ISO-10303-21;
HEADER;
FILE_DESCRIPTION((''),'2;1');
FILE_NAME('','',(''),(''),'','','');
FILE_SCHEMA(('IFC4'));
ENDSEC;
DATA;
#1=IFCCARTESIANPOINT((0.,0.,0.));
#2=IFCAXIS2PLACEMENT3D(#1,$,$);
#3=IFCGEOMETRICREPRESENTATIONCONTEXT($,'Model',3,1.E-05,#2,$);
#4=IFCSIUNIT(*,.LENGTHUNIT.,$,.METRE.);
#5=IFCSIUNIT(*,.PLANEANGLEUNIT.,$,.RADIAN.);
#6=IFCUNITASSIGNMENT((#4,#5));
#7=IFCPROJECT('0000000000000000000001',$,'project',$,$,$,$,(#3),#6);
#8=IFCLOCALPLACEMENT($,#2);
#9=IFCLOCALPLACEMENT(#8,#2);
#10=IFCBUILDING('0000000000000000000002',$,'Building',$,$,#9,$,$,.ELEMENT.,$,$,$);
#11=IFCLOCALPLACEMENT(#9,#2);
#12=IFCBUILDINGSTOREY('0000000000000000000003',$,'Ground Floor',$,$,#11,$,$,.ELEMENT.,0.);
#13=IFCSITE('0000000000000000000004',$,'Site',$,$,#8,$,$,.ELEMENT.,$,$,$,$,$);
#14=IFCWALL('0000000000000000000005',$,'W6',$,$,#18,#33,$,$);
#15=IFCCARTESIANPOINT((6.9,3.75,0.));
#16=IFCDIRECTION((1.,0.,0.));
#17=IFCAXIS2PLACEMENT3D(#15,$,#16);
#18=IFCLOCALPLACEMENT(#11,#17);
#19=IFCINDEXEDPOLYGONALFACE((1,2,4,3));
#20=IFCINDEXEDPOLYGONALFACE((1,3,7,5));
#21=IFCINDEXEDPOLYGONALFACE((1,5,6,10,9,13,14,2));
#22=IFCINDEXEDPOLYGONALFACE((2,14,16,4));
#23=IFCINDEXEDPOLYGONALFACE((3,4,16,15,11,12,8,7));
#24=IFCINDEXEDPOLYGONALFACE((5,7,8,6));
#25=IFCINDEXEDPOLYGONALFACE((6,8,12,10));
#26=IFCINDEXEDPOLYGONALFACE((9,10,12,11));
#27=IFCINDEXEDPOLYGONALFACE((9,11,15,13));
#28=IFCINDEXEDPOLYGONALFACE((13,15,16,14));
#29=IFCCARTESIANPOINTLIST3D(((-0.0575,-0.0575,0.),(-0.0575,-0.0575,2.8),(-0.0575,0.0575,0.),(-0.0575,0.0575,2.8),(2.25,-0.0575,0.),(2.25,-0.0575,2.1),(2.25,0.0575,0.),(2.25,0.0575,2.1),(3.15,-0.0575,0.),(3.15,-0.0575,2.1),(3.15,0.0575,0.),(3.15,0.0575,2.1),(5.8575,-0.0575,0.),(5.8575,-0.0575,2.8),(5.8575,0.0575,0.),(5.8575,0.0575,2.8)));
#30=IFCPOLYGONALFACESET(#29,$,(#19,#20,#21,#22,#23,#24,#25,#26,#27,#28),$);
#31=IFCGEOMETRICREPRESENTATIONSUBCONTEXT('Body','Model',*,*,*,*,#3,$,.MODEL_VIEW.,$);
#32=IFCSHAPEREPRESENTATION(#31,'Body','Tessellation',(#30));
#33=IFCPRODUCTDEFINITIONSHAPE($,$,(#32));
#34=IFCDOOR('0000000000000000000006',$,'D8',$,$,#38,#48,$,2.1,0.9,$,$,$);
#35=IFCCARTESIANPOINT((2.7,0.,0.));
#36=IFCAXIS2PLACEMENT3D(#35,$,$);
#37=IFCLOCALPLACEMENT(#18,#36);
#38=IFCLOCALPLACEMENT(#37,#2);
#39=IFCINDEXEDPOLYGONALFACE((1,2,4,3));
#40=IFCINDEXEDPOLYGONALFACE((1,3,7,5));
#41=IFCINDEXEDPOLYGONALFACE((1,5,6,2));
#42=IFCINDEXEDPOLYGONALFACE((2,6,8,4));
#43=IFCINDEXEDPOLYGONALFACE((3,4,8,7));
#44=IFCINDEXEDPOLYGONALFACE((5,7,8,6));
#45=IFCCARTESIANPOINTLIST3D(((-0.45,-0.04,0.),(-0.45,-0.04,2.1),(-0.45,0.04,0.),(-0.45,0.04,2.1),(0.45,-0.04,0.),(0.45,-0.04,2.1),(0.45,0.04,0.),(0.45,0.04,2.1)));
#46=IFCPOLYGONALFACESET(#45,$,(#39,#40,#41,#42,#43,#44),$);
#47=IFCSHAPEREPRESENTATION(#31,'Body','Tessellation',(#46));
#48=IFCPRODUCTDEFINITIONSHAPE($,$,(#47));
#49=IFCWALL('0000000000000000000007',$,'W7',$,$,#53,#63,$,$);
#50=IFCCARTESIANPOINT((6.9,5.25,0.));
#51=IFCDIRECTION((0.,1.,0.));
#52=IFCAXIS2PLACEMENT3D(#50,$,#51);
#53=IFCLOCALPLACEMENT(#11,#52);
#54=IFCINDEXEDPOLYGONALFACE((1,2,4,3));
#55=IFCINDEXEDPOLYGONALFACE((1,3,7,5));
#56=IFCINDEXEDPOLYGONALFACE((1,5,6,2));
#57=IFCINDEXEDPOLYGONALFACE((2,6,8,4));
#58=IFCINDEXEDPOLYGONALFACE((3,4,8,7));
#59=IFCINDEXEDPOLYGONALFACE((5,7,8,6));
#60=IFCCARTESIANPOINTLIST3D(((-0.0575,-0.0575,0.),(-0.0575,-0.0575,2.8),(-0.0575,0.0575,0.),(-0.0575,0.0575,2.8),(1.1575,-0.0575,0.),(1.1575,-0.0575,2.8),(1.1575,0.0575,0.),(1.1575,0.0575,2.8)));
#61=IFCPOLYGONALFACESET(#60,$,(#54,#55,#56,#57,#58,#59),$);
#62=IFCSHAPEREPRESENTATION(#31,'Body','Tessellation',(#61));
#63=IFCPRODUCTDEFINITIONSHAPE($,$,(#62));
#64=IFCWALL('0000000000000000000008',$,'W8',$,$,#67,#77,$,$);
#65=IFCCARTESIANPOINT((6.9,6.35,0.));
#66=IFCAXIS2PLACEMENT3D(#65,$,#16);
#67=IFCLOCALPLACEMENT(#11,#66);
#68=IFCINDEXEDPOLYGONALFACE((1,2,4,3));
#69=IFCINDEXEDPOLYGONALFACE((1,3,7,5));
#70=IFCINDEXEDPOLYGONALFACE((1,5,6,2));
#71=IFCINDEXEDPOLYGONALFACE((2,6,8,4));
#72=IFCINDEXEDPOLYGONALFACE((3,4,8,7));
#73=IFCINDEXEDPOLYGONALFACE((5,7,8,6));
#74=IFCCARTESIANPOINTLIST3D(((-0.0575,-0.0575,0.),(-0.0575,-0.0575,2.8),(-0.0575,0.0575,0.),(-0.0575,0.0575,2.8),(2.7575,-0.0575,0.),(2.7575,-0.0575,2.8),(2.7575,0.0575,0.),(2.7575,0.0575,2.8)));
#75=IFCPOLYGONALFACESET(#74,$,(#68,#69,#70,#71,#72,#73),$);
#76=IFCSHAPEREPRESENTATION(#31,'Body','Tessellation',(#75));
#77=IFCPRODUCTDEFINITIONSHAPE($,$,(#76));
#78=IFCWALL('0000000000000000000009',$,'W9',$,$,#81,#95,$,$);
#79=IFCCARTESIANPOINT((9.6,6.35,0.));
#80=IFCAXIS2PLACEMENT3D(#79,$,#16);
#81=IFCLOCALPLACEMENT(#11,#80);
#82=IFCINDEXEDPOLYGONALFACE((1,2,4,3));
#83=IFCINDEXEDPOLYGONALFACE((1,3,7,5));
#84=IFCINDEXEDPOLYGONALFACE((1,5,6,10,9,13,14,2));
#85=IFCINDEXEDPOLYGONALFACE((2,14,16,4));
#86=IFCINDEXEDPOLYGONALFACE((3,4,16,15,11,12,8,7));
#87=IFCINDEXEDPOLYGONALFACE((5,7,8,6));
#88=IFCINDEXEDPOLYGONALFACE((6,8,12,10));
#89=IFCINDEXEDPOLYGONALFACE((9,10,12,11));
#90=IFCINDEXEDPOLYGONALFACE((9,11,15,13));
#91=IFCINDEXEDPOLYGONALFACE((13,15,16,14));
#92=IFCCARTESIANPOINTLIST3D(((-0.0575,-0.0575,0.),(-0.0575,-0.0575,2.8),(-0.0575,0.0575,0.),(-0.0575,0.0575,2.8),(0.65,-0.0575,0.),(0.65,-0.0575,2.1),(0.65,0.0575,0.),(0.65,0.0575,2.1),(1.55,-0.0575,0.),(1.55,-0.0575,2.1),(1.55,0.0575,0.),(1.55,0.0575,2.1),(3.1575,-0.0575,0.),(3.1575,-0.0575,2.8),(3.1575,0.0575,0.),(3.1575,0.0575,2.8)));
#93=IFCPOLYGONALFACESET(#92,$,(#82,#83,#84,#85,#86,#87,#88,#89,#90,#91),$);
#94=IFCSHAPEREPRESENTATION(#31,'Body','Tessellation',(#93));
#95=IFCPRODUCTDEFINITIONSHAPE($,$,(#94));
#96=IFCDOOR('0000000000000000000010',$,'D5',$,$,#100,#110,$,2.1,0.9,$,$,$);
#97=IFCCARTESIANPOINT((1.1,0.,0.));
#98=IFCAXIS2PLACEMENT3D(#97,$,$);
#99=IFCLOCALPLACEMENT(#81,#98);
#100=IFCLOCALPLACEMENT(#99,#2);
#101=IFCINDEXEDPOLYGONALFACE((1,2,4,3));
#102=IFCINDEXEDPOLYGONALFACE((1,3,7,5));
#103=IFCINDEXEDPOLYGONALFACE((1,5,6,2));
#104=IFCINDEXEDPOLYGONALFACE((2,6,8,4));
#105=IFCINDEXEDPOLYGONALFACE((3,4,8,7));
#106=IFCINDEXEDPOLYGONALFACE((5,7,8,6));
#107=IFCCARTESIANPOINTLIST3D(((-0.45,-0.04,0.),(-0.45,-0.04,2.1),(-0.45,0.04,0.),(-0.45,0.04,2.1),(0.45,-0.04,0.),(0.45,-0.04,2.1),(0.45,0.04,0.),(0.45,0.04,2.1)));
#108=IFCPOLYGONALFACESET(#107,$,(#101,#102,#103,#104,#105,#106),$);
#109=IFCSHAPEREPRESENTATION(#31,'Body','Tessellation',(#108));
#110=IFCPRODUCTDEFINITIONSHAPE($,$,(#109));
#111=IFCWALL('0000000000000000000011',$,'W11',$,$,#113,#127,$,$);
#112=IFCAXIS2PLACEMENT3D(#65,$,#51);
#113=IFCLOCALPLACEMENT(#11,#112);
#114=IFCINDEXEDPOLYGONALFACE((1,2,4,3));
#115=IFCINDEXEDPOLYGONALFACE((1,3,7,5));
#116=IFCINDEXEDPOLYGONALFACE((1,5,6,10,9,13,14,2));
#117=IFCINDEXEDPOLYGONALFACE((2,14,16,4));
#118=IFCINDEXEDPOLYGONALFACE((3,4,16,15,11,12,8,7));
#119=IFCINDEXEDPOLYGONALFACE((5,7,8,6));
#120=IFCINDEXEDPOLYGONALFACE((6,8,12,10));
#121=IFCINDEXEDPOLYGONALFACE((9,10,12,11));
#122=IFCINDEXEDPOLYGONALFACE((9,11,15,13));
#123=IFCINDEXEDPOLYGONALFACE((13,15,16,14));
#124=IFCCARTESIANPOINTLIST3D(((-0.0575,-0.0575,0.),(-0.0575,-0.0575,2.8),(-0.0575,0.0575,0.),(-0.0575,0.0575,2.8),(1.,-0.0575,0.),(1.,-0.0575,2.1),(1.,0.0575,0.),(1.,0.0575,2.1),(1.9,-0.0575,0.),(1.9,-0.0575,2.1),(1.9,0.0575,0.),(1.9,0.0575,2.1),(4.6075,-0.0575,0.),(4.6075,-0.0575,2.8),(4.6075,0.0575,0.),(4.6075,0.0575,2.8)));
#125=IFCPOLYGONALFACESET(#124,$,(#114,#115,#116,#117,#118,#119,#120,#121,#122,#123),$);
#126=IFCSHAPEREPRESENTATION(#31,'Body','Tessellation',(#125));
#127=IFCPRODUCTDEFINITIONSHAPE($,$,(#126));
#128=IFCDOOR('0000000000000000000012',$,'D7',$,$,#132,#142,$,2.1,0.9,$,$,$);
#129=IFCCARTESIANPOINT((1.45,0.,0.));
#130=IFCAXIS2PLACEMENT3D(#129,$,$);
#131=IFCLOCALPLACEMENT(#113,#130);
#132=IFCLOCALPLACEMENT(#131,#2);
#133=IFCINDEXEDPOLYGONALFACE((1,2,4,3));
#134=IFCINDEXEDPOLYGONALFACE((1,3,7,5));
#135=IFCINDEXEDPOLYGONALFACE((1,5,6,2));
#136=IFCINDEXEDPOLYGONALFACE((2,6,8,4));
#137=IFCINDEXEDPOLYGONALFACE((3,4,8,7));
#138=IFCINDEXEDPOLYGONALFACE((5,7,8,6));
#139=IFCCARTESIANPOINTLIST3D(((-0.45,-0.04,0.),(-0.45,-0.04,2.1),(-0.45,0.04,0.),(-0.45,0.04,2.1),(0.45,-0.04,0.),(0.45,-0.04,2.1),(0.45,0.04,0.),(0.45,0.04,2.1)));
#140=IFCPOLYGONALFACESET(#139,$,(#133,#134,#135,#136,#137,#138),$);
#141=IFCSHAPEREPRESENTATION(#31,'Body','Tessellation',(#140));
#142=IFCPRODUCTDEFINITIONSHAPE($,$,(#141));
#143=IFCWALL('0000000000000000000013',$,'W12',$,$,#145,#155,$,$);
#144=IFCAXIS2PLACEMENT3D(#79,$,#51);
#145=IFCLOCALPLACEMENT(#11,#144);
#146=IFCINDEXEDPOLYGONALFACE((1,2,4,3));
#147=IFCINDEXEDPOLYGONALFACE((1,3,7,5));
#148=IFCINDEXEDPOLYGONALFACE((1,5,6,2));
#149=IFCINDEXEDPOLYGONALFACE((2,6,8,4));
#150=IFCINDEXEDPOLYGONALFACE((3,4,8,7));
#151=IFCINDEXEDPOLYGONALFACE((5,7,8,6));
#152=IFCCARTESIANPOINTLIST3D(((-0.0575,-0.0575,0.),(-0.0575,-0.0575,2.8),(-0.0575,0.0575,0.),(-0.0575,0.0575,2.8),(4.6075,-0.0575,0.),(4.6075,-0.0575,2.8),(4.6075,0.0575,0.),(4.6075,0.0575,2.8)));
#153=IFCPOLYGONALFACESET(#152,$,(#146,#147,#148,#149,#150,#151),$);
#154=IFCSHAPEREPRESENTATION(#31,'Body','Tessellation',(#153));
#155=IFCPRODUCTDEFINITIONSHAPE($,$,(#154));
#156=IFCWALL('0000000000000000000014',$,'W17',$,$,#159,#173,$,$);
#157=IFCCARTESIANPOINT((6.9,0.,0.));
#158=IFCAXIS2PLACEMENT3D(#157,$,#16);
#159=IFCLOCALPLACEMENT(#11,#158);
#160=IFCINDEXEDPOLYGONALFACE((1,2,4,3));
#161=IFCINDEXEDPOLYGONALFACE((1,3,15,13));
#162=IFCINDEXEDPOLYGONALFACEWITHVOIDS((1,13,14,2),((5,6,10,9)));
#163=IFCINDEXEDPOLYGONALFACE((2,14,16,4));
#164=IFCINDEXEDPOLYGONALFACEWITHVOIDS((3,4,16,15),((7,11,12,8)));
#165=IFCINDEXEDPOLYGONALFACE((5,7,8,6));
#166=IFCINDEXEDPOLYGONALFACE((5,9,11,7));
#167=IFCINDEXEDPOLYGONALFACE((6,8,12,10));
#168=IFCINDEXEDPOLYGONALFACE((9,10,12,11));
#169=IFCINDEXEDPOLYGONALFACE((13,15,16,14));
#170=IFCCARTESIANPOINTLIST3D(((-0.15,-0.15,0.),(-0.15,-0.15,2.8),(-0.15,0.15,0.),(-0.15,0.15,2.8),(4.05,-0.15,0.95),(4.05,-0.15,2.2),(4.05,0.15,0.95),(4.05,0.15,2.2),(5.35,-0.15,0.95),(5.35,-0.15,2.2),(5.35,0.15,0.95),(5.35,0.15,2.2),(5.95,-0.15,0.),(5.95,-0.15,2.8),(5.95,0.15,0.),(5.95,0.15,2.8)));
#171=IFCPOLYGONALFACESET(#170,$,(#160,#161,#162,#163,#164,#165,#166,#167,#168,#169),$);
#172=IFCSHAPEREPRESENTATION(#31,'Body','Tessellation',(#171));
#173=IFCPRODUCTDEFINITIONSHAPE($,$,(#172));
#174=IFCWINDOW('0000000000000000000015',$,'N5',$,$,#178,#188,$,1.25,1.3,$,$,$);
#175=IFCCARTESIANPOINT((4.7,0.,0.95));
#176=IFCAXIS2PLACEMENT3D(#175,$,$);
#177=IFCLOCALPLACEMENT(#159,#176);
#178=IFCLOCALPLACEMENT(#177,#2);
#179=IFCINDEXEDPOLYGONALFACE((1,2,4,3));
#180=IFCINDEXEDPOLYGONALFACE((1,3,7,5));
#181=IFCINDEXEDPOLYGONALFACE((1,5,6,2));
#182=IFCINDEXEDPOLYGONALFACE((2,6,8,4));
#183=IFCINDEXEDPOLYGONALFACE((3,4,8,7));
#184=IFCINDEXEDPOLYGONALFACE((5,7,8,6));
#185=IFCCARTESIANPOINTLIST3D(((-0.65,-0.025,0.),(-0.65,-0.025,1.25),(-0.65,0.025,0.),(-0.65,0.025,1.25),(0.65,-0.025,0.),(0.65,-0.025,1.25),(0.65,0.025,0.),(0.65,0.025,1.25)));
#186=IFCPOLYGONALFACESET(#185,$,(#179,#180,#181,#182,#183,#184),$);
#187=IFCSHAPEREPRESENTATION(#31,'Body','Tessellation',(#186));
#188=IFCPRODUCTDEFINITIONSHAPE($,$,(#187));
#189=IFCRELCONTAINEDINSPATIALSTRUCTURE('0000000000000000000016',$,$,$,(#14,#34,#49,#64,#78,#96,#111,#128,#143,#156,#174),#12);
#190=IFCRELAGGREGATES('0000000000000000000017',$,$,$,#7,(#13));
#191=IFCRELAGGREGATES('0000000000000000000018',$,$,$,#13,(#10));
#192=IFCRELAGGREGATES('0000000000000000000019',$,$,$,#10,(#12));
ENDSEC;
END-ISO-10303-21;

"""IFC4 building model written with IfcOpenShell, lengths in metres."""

from ifc_helpers import new_model, si_unit, frame, frame_2d, origin, origin_2d, place, context, subcontext, project, spatial, rectangle, extrude, element, fill, save


model = new_model("IFC4")

# Units and contexts
model_context = context("Model", 3, precision=1e-05, world=origin())
body_context = subcontext(model_context, "Body", "Model", "MODEL_VIEW")
ifc_project = project(units=[si_unit("LENGTHUNIT", "METRE"), si_unit("PLANEANGLEUNIT", "RADIAN")], contexts=[model_context])

# Site, building, storey
site_placement = place(None, origin())
site = spatial("IfcSite", under=ifc_project, at=site_placement, Name="Site", CompositionType="ELEMENT")
building_placement = place(site_placement, origin())
building = spatial("IfcBuilding", under=site, at=building_placement, Name="Building", CompositionType="ELEMENT")
storey_placement = place(building_placement, origin())
storey = spatial("IfcBuildingStorey", under=building, at=storey_placement, Name="Ground Floor", CompositionType="ELEMENT", Elevation=0.0)

# Wall, opening, door
wall_1_placement = place(storey_placement, frame((6.9, 3.75, 0.0), x_axis=(1.0, 0.0, 0.0)))
wall_1 = element("IfcWall", 1, at=wall_1_placement, inside=storey, Name="W6", context=body_context, shape_type="SweptSolid", body=[
    extrude(rectangle(XDim=5.915, YDim=0.115, at=frame_2d((2.9, 0.0))), origin(), (0.0, 0.0, 1.0), 2.8),
])
opening_1_placement = place(wall_1_placement, frame((2.7, 0.0, 0.0)))
opening_1 = element("IfcOpeningElement", 2, at=opening_1_placement, cuts=wall_1, context=body_context, shape_type="SweptSolid", body=[
    extrude(rectangle(XDim=0.9, YDim=0.215, at=origin_2d()), origin(), (0.0, 0.0, 1.0), 2.1),
])
door_1_placement = place(opening_1_placement, origin())
door_1 = element("IfcDoor", 3, at=door_1_placement, inside=storey, Name="D8", OverallHeight=2.1, OverallWidth=0.9, context=body_context, shape_type="SweptSolid", body=[
    extrude(rectangle(XDim=0.9, YDim=0.08, at=origin_2d()), origin(), (0.0, 0.0, 1.0), 2.1),
])
fill(opening_1, door_1)

# Walls
wall_2_placement = place(storey_placement, frame((6.9, 5.25, 0.0), x_axis=(0.0, 1.0, 0.0)))
element("IfcWall", 4, at=wall_2_placement, inside=storey, Name="W7", context=body_context, shape_type="SweptSolid", body=[
    extrude(rectangle(XDim=1.215, YDim=0.115, at=frame_2d((0.55, 0.0))), origin(), (0.0, 0.0, 1.0), 2.8),
])
wall_3_placement = place(storey_placement, frame((6.9, 6.35, 0.0), x_axis=(1.0, 0.0, 0.0)))
element("IfcWall", 5, at=wall_3_placement, inside=storey, Name="W8", context=body_context, shape_type="SweptSolid", body=[
    extrude(rectangle(XDim=2.815, YDim=0.115, at=frame_2d((1.35, 0.0))), origin(), (0.0, 0.0, 1.0), 2.8),
])

# Walls, openings, doors
wall_4_placement = place(storey_placement, frame((9.6, 6.35, 0.0), x_axis=(1.0, 0.0, 0.0)))
wall_4 = element("IfcWall", 6, at=wall_4_placement, inside=storey, Name="W9", context=body_context, shape_type="SweptSolid", body=[
    extrude(rectangle(XDim=3.215, YDim=0.115, at=frame_2d((1.55, 0.0))), origin(), (0.0, 0.0, 1.0), 2.8),
])
opening_2_placement = place(wall_4_placement, frame((1.1, 0.0, 0.0)))
opening_2 = element("IfcOpeningElement", 7, at=opening_2_placement, cuts=wall_4, context=body_context, shape_type="SweptSolid", body=[
    extrude(rectangle(XDim=0.9, YDim=0.215, at=origin_2d()), origin(), (0.0, 0.0, 1.0), 2.1),
])
door_2_placement = place(opening_2_placement, origin())
door_2 = element("IfcDoor", 8, at=door_2_placement, inside=storey, Name="D5", OverallHeight=2.1, OverallWidth=0.9, context=body_context, shape_type="SweptSolid", body=[
    extrude(rectangle(XDim=0.9, YDim=0.08, at=origin_2d()), origin(), (0.0, 0.0, 1.0), 2.1),
])
fill(opening_2, door_2)
wall_5_placement = place(storey_placement, frame((6.9, 6.35, 0.0), x_axis=(0.0, 1.0, 0.0)))
wall_5 = element("IfcWall", 9, at=wall_5_placement, inside=storey, Name="W11", context=body_context, shape_type="SweptSolid", body=[
    extrude(rectangle(XDim=4.665, YDim=0.115, at=frame_2d((2.275, 0.0))), origin(), (0.0, 0.0, 1.0), 2.8),
])
opening_3_placement = place(wall_5_placement, frame((1.45, 0.0, 0.0)))
opening_3 = element("IfcOpeningElement", 10, at=opening_3_placement, cuts=wall_5, context=body_context, shape_type="SweptSolid", body=[
    extrude(rectangle(XDim=0.9, YDim=0.215, at=origin_2d()), origin(), (0.0, 0.0, 1.0), 2.1),
])
door_3_placement = place(opening_3_placement, origin())
door_3 = element("IfcDoor", 11, at=door_3_placement, inside=storey, Name="D7", OverallHeight=2.1, OverallWidth=0.9, context=body_context, shape_type="SweptSolid", body=[
    extrude(rectangle(XDim=0.9, YDim=0.08, at=origin_2d()), origin(), (0.0, 0.0, 1.0), 2.1),
])
fill(opening_3, door_3)

# Wall
wall_6_placement = place(storey_placement, frame((9.6, 6.35, 0.0), x_axis=(0.0, 1.0, 0.0)))
element("IfcWall", 12, at=wall_6_placement, inside=storey, Name="W12", context=body_context, shape_type="SweptSolid", body=[
    extrude(rectangle(XDim=4.665, YDim=0.115, at=frame_2d((2.275, 0.0))), origin(), (0.0, 0.0, 1.0), 2.8),
])

# Wall, opening, window
wall_7_placement = place(storey_placement, frame((6.9, 0.0, 0.0), x_axis=(1.0, 0.0, 0.0)))
wall_7 = element("IfcWall", 13, at=wall_7_placement, inside=storey, Name="W17", context=body_context, shape_type="SweptSolid", body=[
    extrude(rectangle(XDim=6.1, YDim=0.3, at=frame_2d((2.9, 0.0))), origin(), (0.0, 0.0, 1.0), 2.8),
])
opening_4_placement = place(wall_7_placement, frame((4.7, 0.0, 0.95)))
opening_4 = element("IfcOpeningElement", 14, at=opening_4_placement, cuts=wall_7, context=body_context, shape_type="SweptSolid", body=[
    extrude(rectangle(XDim=1.3, YDim=0.4, at=origin_2d()), origin(), (0.0, 0.0, 1.0), 1.25),
])
window_1_placement = place(opening_4_placement, origin())
window_1 = element("IfcWindow", 15, at=window_1_placement, inside=storey, Name="N5", OverallHeight=1.25, OverallWidth=1.3, context=body_context, shape_type="SweptSolid", body=[
    extrude(rectangle(XDim=1.3, YDim=0.05, at=origin_2d()), origin(), (0.0, 0.0, 1.0), 1.25),
])
fill(opening_4, window_1)

save(model, "model.ifc")
